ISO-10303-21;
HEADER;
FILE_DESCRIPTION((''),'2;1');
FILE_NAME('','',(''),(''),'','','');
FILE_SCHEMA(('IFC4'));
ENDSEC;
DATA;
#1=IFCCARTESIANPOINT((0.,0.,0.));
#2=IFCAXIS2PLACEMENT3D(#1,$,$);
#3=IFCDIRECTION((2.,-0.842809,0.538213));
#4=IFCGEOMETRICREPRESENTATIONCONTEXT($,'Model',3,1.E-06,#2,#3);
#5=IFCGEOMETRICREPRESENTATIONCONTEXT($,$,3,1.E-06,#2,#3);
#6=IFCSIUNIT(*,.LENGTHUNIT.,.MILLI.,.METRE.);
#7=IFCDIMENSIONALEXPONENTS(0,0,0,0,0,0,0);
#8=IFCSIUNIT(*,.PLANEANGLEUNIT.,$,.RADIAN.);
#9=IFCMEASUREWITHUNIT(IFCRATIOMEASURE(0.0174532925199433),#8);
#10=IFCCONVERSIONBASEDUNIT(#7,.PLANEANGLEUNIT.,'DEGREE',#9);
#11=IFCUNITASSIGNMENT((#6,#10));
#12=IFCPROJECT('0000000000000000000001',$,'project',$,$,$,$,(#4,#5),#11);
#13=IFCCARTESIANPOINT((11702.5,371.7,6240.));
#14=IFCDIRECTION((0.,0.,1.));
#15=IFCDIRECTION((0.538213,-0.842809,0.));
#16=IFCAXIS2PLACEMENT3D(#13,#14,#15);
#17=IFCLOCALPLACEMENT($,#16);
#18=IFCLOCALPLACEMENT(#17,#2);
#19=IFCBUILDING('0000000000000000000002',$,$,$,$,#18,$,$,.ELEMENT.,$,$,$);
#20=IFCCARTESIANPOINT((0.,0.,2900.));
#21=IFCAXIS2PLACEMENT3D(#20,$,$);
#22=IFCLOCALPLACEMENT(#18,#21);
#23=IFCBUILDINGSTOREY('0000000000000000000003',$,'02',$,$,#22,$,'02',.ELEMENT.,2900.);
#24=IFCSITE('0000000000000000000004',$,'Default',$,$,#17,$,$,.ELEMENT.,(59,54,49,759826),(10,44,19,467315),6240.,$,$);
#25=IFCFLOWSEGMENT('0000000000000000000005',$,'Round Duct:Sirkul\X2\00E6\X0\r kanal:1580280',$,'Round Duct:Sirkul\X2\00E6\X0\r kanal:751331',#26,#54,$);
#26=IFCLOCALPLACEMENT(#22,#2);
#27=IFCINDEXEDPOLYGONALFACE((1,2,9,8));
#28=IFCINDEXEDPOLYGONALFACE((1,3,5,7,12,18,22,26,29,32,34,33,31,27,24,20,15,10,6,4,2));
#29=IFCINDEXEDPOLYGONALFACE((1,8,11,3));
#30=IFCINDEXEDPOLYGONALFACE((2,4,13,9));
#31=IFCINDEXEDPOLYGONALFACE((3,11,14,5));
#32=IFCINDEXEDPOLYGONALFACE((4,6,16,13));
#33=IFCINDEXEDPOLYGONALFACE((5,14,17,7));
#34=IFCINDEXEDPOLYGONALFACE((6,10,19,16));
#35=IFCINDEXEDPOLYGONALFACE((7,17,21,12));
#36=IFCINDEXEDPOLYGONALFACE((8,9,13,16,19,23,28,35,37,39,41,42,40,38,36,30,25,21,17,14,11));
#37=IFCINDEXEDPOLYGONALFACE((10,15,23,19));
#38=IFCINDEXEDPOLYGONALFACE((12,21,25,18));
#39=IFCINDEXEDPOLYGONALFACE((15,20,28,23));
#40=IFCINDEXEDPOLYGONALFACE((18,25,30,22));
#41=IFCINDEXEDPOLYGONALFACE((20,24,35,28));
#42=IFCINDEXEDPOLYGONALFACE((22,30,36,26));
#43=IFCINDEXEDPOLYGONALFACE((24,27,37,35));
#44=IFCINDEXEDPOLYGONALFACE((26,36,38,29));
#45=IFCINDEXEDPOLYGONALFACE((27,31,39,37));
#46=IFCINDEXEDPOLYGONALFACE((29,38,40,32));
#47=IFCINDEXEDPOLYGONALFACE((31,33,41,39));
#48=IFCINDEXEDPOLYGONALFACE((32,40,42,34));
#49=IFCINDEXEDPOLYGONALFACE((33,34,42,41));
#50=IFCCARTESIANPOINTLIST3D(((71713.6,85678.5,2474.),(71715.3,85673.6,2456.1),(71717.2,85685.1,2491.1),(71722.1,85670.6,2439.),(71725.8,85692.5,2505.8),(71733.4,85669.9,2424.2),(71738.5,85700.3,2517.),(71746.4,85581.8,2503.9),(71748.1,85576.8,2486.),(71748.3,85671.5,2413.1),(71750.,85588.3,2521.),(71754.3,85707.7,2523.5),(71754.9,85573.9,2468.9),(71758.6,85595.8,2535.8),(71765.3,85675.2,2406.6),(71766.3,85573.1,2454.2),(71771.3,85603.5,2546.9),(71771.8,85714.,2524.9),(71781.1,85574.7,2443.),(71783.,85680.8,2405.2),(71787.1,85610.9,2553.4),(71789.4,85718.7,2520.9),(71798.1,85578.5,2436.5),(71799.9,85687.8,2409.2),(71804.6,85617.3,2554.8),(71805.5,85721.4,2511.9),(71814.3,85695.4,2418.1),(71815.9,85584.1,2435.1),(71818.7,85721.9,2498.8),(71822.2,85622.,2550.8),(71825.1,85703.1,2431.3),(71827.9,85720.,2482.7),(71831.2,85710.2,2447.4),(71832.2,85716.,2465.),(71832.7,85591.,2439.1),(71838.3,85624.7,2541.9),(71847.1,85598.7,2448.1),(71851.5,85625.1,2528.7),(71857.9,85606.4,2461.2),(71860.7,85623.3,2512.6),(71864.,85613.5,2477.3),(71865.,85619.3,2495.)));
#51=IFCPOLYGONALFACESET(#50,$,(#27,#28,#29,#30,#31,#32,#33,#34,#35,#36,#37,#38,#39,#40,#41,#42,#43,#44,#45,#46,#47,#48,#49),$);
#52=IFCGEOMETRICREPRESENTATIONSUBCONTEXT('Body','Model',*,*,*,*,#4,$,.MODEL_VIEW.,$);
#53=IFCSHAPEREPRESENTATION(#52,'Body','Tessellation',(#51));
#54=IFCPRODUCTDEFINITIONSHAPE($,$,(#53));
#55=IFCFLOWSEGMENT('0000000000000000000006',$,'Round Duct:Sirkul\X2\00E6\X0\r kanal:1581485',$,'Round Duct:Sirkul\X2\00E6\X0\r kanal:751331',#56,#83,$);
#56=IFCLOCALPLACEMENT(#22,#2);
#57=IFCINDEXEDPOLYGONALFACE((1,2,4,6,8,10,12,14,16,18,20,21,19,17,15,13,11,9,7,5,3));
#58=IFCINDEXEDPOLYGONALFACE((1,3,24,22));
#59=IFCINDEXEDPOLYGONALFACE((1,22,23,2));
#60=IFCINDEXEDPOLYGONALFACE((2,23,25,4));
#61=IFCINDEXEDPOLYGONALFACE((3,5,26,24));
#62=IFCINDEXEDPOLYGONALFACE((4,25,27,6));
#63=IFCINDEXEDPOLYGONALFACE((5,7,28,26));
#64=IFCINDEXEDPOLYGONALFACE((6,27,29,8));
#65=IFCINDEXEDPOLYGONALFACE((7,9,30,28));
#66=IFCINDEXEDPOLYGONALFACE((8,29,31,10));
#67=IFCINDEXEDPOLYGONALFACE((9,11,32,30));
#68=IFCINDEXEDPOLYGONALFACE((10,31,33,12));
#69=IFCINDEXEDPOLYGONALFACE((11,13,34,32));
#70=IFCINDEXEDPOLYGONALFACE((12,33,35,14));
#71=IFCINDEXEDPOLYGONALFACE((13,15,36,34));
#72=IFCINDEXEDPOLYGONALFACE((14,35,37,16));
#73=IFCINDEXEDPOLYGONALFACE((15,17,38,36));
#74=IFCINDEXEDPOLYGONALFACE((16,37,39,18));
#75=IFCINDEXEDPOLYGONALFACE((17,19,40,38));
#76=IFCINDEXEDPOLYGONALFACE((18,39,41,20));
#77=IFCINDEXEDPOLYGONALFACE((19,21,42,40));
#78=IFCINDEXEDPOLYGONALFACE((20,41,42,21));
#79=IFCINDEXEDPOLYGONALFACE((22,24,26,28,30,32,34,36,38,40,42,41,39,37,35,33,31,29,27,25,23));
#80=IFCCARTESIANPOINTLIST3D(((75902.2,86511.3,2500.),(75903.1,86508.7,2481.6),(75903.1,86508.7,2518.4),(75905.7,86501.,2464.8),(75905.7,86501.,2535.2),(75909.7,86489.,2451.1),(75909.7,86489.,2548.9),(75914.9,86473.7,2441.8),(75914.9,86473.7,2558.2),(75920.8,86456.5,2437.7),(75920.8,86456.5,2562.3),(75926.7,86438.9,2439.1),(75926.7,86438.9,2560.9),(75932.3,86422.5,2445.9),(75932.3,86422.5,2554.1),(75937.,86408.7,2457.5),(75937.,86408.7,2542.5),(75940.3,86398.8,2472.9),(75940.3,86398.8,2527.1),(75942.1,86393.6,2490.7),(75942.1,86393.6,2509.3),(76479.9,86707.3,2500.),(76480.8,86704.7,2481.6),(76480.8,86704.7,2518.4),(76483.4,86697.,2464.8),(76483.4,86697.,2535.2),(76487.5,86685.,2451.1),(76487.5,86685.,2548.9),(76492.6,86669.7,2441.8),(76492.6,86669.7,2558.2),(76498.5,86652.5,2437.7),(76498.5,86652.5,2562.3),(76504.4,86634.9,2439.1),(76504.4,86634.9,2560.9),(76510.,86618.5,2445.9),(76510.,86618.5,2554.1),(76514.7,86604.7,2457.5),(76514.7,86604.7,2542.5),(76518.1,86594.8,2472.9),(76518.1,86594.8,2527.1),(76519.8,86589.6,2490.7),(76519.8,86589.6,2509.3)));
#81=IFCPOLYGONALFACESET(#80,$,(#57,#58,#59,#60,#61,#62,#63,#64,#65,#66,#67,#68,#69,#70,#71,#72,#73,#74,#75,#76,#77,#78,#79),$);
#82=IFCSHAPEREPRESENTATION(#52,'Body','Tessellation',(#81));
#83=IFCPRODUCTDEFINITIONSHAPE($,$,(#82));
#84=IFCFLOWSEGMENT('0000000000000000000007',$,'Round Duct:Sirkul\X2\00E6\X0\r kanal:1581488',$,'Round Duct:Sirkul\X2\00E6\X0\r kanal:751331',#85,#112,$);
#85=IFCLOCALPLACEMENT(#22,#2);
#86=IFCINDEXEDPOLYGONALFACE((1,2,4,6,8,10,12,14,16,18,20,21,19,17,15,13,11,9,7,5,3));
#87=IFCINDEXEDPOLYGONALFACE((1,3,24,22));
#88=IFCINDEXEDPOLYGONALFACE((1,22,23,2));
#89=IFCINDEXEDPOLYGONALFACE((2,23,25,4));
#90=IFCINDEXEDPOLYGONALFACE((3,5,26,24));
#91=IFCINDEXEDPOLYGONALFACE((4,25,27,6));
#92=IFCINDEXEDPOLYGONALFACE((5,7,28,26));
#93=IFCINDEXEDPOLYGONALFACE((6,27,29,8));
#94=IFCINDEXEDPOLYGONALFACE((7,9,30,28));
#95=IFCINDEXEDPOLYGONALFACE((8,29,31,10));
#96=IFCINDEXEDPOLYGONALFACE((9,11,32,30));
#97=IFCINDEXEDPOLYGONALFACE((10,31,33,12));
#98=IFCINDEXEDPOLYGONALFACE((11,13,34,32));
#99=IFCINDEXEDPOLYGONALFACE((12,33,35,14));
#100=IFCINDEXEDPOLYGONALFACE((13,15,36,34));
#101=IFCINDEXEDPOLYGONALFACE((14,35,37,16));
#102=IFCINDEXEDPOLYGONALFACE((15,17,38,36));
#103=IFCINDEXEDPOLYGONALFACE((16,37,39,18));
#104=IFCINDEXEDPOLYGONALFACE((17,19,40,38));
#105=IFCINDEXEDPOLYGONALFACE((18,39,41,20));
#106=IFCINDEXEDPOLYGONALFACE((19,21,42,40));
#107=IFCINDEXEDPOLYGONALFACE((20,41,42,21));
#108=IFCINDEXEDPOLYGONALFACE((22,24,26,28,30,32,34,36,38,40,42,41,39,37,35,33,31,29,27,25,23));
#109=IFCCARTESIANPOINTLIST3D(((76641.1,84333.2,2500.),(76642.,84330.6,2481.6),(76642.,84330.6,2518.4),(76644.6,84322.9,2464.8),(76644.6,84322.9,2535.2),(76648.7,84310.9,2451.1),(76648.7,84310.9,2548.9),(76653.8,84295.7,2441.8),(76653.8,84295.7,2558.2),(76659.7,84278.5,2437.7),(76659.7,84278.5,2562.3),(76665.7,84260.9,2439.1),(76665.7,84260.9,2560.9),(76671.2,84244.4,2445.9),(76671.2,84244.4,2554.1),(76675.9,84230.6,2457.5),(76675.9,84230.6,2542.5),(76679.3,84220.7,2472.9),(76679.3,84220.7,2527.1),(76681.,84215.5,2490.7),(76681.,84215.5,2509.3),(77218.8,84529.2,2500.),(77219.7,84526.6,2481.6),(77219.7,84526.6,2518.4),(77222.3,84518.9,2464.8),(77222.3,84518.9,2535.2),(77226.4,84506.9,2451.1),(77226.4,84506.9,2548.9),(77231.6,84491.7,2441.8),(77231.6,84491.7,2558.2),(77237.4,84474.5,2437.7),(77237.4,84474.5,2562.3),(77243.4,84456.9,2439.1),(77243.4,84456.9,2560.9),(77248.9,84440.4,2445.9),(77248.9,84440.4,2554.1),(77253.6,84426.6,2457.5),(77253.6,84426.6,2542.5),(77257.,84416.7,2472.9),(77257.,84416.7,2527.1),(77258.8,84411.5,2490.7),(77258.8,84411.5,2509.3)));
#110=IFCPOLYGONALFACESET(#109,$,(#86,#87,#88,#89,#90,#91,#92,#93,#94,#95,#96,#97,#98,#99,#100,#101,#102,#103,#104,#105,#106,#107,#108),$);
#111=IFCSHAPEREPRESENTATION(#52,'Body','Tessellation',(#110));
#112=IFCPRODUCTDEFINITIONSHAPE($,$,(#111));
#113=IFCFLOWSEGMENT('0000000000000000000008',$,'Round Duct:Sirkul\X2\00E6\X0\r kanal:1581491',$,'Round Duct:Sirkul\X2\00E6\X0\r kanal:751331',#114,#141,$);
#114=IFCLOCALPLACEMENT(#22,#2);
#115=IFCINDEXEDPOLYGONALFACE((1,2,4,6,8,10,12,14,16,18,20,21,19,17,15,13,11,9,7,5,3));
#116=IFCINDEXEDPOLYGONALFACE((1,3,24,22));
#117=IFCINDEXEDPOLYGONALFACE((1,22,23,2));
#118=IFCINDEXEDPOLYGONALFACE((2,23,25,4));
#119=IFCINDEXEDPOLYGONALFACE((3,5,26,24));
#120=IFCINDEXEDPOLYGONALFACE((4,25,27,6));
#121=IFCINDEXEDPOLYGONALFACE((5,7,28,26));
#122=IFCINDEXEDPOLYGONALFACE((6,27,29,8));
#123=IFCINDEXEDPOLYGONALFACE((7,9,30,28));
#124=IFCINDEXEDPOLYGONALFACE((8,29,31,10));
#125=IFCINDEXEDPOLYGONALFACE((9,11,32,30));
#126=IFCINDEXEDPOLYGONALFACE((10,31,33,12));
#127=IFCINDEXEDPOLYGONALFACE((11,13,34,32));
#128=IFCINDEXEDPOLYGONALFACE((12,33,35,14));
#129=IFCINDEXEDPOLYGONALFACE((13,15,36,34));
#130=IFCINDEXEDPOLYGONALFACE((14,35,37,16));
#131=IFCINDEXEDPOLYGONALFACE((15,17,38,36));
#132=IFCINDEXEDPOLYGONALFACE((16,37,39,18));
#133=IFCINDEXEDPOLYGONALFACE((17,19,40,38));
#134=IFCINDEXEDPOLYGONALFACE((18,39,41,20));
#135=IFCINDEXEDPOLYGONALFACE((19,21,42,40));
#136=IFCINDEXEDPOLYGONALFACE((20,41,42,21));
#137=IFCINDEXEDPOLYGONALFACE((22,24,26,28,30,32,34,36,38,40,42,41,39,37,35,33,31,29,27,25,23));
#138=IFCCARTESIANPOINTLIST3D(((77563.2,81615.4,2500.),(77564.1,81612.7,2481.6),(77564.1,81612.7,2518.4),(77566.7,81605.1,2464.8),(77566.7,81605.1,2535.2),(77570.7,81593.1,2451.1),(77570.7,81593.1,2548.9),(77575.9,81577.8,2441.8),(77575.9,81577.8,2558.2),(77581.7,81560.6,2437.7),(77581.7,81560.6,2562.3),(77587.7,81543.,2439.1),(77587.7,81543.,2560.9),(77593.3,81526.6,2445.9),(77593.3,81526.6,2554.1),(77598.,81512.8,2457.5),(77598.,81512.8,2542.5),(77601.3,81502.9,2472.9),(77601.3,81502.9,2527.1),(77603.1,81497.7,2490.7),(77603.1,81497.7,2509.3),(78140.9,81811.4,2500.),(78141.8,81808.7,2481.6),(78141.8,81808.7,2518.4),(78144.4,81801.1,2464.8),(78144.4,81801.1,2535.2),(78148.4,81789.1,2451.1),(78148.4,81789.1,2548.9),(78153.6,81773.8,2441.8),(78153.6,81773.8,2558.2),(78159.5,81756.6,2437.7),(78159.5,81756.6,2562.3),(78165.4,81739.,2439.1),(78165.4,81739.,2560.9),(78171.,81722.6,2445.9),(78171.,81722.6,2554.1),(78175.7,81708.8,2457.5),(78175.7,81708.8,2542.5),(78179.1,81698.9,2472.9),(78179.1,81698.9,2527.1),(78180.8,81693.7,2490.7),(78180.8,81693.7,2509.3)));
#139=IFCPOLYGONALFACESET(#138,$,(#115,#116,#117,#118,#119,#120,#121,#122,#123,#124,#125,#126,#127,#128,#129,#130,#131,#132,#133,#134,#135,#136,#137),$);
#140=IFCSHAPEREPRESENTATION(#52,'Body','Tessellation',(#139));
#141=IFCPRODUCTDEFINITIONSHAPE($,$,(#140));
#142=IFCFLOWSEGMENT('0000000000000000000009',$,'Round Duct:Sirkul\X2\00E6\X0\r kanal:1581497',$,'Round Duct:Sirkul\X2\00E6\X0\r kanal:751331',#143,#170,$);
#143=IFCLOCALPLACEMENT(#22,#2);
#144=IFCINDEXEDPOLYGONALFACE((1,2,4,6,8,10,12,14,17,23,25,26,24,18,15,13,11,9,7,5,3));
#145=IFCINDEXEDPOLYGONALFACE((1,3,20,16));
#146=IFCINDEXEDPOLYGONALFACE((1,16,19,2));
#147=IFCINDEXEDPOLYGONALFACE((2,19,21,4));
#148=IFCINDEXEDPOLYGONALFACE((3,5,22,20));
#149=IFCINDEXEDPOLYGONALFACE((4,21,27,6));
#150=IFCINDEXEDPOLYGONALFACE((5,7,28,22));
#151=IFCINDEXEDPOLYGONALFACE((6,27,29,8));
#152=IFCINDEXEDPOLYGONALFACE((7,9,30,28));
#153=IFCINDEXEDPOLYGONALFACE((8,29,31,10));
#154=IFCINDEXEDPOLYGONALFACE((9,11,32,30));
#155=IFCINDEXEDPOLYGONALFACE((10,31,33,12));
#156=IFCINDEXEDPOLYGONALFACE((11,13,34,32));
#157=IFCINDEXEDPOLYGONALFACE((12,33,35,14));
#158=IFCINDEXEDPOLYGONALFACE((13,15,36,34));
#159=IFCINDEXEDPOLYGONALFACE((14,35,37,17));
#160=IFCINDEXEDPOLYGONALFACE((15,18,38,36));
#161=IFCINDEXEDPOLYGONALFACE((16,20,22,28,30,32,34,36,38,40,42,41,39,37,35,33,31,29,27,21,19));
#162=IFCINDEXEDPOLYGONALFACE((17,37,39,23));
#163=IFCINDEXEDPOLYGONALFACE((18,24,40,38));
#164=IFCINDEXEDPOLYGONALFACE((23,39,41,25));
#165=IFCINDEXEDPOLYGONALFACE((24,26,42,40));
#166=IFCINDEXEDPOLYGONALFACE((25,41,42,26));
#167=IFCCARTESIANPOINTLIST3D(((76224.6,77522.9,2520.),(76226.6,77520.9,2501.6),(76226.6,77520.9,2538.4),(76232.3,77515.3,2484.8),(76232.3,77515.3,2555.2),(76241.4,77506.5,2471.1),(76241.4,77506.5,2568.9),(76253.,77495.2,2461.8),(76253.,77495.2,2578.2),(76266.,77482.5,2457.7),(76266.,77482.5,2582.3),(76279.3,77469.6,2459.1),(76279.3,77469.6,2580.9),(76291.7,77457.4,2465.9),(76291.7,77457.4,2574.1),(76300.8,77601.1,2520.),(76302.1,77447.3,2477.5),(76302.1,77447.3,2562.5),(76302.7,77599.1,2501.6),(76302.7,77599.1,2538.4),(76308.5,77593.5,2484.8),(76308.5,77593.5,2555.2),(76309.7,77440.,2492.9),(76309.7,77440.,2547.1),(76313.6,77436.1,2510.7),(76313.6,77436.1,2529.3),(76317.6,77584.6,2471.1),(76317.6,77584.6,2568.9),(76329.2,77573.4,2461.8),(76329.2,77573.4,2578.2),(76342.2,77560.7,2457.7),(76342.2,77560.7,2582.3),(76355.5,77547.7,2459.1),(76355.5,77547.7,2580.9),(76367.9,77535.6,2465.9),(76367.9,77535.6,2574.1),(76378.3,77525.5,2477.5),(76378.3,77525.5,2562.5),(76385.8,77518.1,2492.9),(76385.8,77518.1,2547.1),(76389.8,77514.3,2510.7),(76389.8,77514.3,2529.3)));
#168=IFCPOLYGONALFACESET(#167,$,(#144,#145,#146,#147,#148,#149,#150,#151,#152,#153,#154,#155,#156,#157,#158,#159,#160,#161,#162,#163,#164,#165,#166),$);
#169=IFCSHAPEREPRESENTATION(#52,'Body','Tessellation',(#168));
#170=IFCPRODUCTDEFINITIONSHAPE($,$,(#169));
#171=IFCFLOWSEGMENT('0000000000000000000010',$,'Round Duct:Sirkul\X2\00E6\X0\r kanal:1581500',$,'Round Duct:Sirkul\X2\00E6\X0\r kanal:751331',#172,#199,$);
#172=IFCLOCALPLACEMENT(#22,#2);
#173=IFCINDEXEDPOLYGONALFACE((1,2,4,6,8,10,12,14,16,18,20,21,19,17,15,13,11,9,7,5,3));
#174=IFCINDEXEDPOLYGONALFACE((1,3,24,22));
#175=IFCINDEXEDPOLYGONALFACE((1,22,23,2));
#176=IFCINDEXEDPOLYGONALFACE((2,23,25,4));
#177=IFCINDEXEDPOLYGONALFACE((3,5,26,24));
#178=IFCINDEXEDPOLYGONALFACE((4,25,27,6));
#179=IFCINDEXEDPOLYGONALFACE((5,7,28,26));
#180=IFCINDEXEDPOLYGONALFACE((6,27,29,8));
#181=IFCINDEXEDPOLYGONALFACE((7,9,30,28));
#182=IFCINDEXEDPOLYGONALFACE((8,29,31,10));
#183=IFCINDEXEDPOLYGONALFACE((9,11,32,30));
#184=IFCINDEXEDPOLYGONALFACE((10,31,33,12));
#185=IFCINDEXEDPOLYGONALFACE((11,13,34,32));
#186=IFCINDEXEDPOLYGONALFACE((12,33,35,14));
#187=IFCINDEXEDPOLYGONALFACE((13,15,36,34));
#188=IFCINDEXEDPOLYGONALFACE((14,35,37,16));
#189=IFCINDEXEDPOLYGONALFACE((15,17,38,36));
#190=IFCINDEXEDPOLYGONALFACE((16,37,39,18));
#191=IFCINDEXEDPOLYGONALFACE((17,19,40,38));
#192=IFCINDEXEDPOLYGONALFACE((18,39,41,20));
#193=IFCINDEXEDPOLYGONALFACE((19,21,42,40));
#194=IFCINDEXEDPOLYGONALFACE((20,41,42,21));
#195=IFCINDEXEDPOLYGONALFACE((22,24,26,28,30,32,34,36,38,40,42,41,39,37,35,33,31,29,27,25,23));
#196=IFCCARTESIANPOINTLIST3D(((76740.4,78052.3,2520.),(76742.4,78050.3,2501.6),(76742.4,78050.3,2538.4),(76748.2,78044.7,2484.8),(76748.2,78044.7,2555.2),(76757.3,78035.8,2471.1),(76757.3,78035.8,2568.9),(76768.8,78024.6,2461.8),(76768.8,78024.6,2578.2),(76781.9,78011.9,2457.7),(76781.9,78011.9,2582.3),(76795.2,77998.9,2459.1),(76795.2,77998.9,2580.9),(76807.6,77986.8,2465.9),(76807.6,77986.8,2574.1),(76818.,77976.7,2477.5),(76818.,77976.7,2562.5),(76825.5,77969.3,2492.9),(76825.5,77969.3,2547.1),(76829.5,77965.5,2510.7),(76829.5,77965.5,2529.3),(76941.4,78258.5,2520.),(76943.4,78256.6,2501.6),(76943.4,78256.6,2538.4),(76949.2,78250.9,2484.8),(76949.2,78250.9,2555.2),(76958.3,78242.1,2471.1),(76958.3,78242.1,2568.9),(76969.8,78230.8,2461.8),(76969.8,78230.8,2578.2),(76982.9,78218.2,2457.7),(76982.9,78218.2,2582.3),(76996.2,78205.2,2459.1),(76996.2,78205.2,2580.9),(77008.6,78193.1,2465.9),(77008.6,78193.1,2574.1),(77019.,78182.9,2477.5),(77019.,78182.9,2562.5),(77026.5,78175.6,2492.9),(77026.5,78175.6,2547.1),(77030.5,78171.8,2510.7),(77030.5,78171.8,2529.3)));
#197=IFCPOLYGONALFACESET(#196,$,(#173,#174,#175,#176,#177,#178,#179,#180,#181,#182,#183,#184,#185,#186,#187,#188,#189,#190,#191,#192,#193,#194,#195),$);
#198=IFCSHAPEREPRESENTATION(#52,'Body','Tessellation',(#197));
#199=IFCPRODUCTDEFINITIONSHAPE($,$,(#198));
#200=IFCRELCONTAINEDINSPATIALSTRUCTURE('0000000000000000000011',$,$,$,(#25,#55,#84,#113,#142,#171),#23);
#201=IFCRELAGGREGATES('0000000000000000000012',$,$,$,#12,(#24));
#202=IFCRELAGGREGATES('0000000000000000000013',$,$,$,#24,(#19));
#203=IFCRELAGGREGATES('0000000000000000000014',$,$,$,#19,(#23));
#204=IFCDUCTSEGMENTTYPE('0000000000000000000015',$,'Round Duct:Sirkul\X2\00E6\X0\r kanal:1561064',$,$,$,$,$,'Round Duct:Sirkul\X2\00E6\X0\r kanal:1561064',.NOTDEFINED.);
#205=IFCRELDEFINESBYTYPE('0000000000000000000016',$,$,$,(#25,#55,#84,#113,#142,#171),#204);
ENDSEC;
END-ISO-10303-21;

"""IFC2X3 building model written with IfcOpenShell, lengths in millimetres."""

from ifc_helpers import new_model, entity, si_unit, converted_unit, direction, frame, frame_2d, origin, origin_2d_with_axis, place, context, subcontext, project, spatial, circle, extrude, type_object, element, save


model = new_model("IFC2X3")

# Units and contexts
model_context = context("Model", 3, precision=1e-06, world=origin(), true_north=direction((2.0, -0.842809, 0.538213)))
context_of_model = context(None, 3, precision=1e-06, world=origin(), true_north=direction((2.0, -0.842809, 0.538213)))
body_context = subcontext(model_context, "Body", "Model", "MODEL_VIEW")
ifc_project = project(units=[si_unit("LENGTHUNIT", "METRE", prefix="MILLI"), converted_unit("PLANEANGLEUNIT", "DEGREE", entity("IfcRatioMeasure", 0.0174532925199433), si_unit("PLANEANGLEUNIT", "RADIAN"), dimensions=[0, 0, 0, 0, 0, 0, 0])], contexts=[model_context, context_of_model])

# Site, building, storey
site_placement = place(None, frame((11702.5, 371.7, 6240.0), z_axis=(0.0, 0.0, 1.0), x_axis=(0.538213, -0.842809, 0.0)))
site = spatial("IfcSite", under=ifc_project, at=site_placement, Name="Default", CompositionType="ELEMENT", RefLatitude=(59, 54, 49, 759826), RefLongitude=(10, 44, 19, 467315), RefElevation=6240.0)
building_placement = place(site_placement, origin())
building = spatial("IfcBuilding", under=site, at=building_placement, CompositionType="ELEMENT")
storey_placement = place(building_placement, frame((0.0, 0.0, 2900.0)))
storey = spatial("IfcBuildingStorey", under=building, at=storey_placement, Name="02", LongName="02", CompositionType="ELEMENT", Elevation=2900.0)

# Flow segments
duct_segment_type = type_object("IfcDuctSegmentType", Name="Round Duct:Sirkulær kanal:1561064", ElementType="Round Duct:Sirkulær kanal:1561064", PredefinedType="NOTDEFINED")
flow_segment_1_placement = place(storey_placement, origin())
element("IfcFlowSegment", 1, at=flow_segment_1_placement, inside=storey, type_object=duct_segment_type, Name="Round Duct:Sirkulær kanal:1580280", ObjectType="Round Duct:Sirkulær kanal:751331", context=body_context, shape_type="SweptSolid", body=[
    extrude(circle(Radius=62.5, at=frame_2d((0.0, 0.0), x_axis=(1.0, 0.0))), frame((71805.8, 85599.2, 2495.0), z_axis=(-0.308323, 0.908811, -0.281068), x_axis=(0.946986, 0.321274, 0.0)), (0.0, 0.0, 1.0), 106.5),
])
flow_segment_2_placement = place(storey_placement, origin())
element("IfcFlowSegment", 2, at=flow_segment_2_placement, inside=storey, type_object=duct_segment_type, Name="Round Duct:Sirkulær kanal:1581485", ObjectType="Round Duct:Sirkulær kanal:751331", context=body_context, shape_type="SweptSolid", body=[
    extrude(circle(Radius=62.5, at=origin_2d_with_axis()), frame((75922.3, 86452.1, 2500.0), z_axis=(0.946986, 0.321274, 0.0), x_axis=(-0.321274, 0.946986, 0.0)), (0.0, 0.0, 1.0), 610.1),
])
flow_segment_3_placement = place(storey_placement, origin())
element("IfcFlowSegment", 3, at=flow_segment_3_placement, inside=storey, type_object=duct_segment_type, Name="Round Duct:Sirkulær kanal:1581488", ObjectType="Round Duct:Sirkulær kanal:751331", context=body_context, shape_type="SweptSolid", body=[
    extrude(circle(Radius=62.5, at=origin_2d_with_axis()), frame((76661.2, 84274.0, 2500.0), z_axis=(0.946986, 0.321274, 0.0), x_axis=(-0.321274, 0.946986, 0.0)), (0.0, 0.0, 1.0), 610.1),
])
flow_segment_4_placement = place(storey_placement, origin())
element("IfcFlowSegment", 4, at=flow_segment_4_placement, inside=storey, type_object=duct_segment_type, Name="Round Duct:Sirkulær kanal:1581491", ObjectType="Round Duct:Sirkulær kanal:751331", context=body_context, shape_type="SweptSolid", body=[
    extrude(circle(Radius=62.5, at=origin_2d_with_axis()), frame((77583.2, 81556.2, 2500.0), z_axis=(0.946986, 0.321274, 0.0), x_axis=(-0.321274, 0.946986, 0.0)), (0.0, 0.0, 1.0), 610.1),
])
flow_segment_5_placement = place(storey_placement, origin())
element("IfcFlowSegment", 5, at=flow_segment_5_placement, inside=storey, type_object=duct_segment_type, Name="Round Duct:Sirkulær kanal:1581497", ObjectType="Round Duct:Sirkulær kanal:751331", context=body_context, shape_type="SweptSolid", body=[
    extrude(circle(Radius=62.5, at=origin_2d_with_axis()), frame((76269.3, 77479.3, 2520.0), z_axis=(0.697915, 0.71618, 0.0), x_axis=(-0.71618, 0.697915, 0.0)), (0.0, 0.0, 1.0), 109.2),
])
flow_segment_6_placement = place(storey_placement, origin())
element("IfcFlowSegment", 6, at=flow_segment_6_placement, inside=storey, type_object=duct_segment_type, Name="Round Duct:Sirkulær kanal:1581500", ObjectType="Round Duct:Sirkulær kanal:751331", context=body_context, shape_type="SweptSolid", body=[
    extrude(circle(Radius=62.5, at=origin_2d_with_axis()), frame((76785.2, 78008.6, 2520.0), z_axis=(0.697915, 0.71618, 0.0), x_axis=(-0.71618, 0.697915, 0.0)), (0.0, 0.0, 1.0), 288.0),
])

save(model, "model.ifc")
